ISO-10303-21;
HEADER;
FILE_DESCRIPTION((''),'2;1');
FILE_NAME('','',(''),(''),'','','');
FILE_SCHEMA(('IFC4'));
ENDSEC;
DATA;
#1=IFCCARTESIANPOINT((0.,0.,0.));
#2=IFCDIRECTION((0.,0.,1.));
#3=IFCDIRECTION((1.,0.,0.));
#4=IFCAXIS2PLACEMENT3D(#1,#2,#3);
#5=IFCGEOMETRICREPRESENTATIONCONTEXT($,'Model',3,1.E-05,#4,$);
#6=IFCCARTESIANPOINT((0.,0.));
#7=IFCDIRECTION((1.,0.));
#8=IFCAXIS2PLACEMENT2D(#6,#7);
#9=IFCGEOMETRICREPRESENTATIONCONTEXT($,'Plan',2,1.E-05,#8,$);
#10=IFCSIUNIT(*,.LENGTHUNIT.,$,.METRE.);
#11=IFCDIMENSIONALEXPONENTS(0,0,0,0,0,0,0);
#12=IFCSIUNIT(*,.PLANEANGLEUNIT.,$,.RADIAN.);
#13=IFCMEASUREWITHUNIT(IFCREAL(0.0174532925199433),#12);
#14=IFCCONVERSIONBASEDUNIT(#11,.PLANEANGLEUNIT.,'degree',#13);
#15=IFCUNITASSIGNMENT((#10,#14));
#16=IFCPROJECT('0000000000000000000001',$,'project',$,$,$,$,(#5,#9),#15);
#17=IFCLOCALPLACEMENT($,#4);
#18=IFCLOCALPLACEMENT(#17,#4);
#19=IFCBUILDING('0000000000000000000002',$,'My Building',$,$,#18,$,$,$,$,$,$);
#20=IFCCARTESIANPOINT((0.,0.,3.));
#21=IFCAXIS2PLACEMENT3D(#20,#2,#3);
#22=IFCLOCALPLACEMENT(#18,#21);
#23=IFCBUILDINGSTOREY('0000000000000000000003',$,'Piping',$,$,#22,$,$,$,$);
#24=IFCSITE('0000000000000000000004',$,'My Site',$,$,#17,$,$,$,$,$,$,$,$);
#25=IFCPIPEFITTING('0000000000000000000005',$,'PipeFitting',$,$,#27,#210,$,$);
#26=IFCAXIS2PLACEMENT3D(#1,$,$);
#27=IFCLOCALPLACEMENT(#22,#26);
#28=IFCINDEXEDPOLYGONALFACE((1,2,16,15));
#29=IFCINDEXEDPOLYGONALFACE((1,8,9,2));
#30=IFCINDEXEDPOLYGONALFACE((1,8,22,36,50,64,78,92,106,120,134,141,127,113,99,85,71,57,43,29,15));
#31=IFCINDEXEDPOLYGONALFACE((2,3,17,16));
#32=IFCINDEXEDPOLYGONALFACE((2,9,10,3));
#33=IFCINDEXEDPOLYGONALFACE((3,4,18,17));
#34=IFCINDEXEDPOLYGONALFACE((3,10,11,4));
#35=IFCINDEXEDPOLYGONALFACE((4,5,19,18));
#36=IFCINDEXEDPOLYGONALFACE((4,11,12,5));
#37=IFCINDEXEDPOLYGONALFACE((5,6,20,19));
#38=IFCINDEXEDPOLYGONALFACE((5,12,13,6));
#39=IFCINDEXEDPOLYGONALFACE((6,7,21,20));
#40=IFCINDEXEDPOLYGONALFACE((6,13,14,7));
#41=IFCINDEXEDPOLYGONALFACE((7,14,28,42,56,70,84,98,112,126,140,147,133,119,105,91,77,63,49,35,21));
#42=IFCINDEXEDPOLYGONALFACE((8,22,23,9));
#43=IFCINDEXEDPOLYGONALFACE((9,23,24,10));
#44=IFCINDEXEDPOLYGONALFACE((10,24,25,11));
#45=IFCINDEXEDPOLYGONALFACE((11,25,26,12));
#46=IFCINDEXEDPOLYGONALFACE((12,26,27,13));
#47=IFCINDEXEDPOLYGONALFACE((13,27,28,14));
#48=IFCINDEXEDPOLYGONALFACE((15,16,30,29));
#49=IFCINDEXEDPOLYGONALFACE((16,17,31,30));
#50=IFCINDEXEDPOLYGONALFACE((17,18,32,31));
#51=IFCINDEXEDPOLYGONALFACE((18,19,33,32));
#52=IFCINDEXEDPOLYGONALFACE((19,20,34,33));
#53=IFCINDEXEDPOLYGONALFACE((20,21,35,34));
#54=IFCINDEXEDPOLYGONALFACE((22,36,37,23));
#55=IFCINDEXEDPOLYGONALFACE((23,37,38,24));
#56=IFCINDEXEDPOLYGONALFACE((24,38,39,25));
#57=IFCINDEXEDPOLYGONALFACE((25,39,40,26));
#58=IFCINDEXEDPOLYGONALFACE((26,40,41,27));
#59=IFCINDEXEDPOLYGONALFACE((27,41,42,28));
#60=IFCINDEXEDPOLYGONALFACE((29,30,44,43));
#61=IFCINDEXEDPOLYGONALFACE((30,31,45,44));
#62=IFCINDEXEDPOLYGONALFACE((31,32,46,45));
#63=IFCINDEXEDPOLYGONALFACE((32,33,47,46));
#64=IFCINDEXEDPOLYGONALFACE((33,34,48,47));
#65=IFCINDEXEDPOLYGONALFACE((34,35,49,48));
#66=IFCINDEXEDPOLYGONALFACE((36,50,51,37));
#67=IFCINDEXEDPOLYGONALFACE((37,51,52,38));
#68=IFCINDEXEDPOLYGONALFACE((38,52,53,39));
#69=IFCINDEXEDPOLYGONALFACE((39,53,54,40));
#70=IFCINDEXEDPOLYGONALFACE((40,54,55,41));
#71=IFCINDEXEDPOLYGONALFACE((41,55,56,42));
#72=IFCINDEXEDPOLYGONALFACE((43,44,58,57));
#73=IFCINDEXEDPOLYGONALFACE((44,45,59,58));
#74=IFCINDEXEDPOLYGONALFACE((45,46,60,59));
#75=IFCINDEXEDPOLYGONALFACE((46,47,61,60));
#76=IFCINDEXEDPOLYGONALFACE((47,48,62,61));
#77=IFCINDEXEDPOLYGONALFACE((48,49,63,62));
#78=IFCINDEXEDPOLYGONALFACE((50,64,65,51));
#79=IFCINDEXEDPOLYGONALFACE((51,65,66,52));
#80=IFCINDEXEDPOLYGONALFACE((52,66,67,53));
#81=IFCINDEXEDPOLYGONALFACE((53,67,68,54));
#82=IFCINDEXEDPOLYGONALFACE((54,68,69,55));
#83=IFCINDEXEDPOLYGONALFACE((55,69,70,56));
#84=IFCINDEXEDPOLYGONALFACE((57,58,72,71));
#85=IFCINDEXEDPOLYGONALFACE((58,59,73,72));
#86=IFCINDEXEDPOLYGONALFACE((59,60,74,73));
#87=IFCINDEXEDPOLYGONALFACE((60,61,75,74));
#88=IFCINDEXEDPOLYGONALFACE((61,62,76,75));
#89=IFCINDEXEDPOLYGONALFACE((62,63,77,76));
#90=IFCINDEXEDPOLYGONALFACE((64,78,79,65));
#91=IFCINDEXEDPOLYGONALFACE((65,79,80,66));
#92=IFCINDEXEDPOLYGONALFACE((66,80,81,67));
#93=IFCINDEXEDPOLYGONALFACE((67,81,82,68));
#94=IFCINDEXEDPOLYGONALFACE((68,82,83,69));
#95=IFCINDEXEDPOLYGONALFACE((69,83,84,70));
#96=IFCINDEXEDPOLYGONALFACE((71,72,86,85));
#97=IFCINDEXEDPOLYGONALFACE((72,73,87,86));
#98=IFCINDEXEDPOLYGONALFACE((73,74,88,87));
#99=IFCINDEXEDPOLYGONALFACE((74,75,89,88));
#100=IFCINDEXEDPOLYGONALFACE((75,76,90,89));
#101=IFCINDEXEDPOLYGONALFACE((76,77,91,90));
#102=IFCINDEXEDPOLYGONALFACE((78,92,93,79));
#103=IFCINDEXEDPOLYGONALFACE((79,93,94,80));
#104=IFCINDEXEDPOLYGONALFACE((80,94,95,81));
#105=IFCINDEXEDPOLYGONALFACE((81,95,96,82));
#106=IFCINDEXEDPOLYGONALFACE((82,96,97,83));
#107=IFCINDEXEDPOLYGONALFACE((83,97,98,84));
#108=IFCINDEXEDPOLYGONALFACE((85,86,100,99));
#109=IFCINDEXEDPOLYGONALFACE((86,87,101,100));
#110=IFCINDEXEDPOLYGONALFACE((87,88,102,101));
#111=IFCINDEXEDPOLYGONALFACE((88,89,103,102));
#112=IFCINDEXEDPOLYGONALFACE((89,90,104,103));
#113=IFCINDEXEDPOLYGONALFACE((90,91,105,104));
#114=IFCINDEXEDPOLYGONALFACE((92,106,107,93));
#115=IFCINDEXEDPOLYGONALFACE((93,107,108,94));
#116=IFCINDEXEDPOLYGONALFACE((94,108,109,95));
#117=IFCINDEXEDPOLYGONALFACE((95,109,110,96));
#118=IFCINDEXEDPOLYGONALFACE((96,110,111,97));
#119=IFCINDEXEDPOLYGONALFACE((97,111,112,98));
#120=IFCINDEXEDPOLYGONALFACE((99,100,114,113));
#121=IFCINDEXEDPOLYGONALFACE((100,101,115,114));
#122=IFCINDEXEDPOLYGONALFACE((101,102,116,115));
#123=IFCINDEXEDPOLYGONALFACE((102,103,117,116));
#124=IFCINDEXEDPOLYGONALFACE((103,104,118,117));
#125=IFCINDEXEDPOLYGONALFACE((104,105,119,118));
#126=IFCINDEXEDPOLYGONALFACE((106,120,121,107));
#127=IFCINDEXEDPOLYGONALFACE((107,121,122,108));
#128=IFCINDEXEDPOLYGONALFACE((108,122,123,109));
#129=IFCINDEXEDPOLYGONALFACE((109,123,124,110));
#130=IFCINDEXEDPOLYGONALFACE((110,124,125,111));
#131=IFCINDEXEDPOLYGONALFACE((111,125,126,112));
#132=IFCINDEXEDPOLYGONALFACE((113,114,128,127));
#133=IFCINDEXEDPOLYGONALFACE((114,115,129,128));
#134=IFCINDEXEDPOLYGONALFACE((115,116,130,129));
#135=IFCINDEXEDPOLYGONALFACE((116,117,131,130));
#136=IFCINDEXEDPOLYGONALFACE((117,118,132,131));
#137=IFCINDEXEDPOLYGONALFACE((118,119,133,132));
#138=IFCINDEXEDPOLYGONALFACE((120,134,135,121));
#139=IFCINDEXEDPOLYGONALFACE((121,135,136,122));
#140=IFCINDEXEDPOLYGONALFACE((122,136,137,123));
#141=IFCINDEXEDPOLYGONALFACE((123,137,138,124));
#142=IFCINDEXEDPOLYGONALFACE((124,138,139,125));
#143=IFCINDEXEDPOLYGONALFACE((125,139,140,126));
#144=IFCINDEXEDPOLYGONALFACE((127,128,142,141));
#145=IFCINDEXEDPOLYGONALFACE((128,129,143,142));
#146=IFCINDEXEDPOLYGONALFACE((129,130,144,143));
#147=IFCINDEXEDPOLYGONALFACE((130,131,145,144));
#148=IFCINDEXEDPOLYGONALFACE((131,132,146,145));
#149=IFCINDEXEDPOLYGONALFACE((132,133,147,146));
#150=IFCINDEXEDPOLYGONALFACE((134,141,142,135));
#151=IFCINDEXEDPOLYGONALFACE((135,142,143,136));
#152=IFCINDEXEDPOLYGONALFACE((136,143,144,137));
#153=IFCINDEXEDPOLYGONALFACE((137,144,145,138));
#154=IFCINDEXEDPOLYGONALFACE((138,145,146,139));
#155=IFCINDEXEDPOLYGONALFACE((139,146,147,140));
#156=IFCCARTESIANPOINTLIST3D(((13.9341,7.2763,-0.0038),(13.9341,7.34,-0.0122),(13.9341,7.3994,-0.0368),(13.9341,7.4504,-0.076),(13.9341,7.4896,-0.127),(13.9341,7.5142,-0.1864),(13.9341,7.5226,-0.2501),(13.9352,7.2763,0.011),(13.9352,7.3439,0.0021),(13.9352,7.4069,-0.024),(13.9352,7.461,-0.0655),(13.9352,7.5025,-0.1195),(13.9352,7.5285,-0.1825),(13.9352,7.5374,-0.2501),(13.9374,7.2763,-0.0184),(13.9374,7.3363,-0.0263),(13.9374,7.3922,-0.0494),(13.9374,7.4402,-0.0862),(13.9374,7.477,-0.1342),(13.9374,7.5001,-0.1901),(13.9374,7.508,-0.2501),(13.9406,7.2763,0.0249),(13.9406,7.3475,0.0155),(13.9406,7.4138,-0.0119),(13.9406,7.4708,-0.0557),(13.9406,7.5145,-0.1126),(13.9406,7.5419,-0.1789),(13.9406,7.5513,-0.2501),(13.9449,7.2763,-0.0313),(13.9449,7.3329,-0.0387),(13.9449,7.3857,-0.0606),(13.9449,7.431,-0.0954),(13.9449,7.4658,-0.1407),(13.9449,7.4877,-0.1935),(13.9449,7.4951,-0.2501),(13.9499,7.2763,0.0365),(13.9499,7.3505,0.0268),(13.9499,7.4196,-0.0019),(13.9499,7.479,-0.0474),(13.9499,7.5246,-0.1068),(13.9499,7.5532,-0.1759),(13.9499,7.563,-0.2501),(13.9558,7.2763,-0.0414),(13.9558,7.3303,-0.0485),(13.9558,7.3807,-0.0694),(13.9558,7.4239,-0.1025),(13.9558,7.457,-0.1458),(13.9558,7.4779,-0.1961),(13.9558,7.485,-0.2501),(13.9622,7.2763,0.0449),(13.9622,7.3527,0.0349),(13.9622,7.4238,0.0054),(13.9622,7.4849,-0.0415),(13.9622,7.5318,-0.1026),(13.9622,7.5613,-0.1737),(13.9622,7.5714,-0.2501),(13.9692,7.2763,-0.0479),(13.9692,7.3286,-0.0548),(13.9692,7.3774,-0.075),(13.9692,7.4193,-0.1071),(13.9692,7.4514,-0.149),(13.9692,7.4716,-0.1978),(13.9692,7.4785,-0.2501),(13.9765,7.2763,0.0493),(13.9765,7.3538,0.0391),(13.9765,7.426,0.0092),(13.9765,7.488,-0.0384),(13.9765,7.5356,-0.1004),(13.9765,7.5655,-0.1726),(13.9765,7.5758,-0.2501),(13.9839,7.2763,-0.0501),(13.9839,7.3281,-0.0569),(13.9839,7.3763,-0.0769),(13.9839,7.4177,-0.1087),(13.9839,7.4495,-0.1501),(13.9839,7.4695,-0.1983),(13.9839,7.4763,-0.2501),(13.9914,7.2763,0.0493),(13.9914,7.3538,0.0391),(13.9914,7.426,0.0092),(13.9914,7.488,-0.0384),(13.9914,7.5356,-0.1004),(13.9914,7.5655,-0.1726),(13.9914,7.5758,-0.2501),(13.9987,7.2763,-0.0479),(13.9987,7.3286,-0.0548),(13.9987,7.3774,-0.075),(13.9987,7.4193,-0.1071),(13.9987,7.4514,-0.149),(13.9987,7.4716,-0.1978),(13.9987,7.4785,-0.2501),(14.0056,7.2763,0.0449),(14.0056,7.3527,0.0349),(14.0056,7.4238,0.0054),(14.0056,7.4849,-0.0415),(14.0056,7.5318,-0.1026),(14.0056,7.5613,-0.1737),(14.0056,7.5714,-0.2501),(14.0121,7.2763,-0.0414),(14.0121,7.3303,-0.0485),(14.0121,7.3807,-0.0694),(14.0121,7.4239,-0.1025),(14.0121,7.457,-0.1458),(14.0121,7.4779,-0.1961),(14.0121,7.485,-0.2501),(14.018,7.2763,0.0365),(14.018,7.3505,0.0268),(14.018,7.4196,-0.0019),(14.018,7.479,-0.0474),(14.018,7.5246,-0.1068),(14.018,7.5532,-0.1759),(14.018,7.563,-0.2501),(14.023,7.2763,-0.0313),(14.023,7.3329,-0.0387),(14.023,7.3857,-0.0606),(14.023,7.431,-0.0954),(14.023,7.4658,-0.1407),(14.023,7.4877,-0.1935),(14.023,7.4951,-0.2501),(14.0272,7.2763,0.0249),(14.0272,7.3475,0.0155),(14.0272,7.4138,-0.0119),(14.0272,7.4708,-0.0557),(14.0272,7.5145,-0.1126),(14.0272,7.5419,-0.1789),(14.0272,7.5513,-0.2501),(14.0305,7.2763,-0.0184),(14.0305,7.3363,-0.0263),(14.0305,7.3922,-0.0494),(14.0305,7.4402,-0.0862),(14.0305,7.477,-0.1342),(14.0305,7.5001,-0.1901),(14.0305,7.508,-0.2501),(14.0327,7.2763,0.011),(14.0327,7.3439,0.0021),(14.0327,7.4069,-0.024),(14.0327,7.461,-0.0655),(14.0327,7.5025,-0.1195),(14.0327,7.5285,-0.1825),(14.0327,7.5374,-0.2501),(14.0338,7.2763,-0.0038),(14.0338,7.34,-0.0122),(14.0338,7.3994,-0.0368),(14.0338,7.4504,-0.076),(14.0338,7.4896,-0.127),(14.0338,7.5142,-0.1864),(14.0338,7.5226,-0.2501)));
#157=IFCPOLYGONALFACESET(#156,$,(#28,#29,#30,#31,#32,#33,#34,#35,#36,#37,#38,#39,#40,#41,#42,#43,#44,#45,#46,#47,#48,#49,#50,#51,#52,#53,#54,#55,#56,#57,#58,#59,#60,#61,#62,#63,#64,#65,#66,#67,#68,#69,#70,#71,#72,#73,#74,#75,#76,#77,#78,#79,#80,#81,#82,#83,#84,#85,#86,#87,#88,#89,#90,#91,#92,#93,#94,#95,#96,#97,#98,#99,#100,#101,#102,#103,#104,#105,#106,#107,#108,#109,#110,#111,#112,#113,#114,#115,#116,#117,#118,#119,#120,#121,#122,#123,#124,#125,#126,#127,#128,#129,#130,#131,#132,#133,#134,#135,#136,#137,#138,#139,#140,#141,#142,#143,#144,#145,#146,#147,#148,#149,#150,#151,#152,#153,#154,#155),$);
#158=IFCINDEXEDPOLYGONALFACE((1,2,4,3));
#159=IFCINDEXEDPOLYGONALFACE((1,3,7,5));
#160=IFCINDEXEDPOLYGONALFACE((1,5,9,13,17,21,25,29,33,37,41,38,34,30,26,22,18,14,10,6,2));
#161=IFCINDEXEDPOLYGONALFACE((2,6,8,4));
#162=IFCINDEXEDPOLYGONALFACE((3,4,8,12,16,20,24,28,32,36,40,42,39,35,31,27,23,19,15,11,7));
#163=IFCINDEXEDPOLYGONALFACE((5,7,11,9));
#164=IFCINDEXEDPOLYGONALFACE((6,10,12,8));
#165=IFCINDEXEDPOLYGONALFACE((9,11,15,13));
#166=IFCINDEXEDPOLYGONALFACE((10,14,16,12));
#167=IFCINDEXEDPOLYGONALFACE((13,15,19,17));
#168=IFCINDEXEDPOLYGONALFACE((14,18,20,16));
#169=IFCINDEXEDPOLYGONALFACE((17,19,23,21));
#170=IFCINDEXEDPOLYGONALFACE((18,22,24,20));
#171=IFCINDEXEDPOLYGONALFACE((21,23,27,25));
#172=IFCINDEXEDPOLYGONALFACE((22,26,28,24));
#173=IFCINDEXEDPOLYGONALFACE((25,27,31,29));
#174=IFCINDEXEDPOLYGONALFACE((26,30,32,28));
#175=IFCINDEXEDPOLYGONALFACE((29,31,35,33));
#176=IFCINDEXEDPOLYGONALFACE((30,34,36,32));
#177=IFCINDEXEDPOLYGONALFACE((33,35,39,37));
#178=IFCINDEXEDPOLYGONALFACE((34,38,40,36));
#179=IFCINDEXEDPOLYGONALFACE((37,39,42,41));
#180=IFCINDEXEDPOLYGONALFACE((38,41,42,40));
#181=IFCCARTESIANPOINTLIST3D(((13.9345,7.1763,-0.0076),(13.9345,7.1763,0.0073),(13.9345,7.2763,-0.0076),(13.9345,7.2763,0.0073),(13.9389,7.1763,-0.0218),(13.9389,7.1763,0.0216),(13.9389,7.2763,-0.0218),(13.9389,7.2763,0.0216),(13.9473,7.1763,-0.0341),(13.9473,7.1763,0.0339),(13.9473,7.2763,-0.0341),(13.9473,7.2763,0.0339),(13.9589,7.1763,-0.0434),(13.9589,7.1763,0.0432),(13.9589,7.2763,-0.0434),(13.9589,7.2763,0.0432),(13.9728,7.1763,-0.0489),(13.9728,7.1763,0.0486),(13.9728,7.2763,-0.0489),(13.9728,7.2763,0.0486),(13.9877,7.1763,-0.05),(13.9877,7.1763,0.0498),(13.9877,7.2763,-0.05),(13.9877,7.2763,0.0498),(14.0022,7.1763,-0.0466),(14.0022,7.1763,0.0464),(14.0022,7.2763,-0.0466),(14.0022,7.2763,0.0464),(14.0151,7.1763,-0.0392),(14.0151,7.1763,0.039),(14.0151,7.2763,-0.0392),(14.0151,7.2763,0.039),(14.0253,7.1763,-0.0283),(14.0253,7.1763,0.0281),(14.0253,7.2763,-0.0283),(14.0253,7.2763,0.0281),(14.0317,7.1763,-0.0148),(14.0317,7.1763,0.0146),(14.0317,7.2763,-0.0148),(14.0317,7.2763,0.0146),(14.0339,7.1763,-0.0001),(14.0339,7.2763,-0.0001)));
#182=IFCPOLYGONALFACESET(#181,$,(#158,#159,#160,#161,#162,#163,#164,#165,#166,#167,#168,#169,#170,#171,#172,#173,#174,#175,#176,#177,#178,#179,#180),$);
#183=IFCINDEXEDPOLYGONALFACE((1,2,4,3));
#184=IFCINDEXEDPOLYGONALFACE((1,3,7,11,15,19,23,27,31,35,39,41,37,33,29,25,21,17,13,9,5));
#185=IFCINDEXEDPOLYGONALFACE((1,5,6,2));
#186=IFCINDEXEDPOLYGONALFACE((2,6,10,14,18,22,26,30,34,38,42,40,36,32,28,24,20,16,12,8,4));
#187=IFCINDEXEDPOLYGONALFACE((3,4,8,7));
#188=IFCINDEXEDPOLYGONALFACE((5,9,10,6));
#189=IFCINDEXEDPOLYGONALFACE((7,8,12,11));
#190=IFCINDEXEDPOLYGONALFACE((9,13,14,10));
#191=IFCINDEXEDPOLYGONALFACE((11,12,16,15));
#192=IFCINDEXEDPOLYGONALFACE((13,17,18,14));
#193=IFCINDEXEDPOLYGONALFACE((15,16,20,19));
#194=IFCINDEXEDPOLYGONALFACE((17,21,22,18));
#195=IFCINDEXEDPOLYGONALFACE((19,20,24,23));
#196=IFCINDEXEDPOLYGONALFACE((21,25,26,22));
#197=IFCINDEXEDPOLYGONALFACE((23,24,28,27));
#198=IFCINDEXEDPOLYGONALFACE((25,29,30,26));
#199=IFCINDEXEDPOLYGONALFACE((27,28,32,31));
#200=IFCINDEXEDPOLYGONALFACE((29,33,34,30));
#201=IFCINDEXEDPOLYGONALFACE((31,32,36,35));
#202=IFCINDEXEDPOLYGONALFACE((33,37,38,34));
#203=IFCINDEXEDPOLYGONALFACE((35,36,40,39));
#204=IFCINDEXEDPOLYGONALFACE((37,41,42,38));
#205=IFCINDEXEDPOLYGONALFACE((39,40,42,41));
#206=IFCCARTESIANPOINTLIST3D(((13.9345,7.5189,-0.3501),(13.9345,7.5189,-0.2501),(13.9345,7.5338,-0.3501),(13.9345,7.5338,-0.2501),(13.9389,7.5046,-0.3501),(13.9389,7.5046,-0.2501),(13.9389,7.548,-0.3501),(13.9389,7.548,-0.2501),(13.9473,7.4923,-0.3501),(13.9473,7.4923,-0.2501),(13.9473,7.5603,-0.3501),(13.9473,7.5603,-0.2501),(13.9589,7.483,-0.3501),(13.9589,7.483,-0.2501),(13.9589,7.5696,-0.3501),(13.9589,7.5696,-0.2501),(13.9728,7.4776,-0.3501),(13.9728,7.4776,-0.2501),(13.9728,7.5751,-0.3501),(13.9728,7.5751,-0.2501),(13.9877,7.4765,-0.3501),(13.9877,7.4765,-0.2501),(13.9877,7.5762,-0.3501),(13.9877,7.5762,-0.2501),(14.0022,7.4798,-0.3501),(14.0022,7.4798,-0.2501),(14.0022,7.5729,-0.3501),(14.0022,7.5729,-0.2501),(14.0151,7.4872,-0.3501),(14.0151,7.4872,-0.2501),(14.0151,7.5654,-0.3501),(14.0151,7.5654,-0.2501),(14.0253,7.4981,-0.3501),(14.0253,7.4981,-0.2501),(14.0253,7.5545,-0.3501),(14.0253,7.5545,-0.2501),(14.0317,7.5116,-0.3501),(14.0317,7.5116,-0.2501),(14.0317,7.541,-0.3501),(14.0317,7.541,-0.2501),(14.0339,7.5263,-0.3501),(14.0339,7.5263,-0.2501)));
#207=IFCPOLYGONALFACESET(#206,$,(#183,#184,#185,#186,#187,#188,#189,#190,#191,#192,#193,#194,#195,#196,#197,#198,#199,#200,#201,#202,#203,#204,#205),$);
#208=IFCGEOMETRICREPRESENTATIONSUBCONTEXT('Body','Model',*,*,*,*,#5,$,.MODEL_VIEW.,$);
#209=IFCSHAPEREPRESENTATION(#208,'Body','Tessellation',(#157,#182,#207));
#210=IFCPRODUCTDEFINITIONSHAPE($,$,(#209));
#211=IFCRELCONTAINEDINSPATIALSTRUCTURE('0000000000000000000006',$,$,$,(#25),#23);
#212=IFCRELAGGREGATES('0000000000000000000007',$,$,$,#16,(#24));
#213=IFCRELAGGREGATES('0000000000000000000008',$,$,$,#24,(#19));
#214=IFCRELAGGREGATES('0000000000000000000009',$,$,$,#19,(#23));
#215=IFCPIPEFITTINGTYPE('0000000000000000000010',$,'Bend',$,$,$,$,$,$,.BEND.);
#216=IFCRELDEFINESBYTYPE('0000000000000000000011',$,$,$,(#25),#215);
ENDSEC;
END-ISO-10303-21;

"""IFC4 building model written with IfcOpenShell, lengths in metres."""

from ifc_helpers import new_model, entity, si_unit, converted_unit, frame, origin_with_axes, origin_2d_with_axis, place, context, subcontext, project, spatial, circle, extrude, source, transform, mapped, type_object, type_shapes, element, save


model = new_model("IFC4")

# Units and contexts
model_context = context("Model", 3, precision=1e-05, world=origin_with_axes())
plan_context = context("Plan", 2, precision=1e-05, world=origin_2d_with_axis())
body_context = subcontext(model_context, "Body", "Model", "MODEL_VIEW")
ifc_project = project(units=[si_unit("LENGTHUNIT", "METRE"), converted_unit("PLANEANGLEUNIT", "degree", entity("IfcReal", 0.0174532925199433), si_unit("PLANEANGLEUNIT", "RADIAN"), dimensions=[0, 0, 0, 0, 0, 0, 0])], contexts=[model_context, plan_context])

# Site, building, storey
site_placement = place(None, origin_with_axes())
site = spatial("IfcSite", under=ifc_project, at=site_placement, Name="My Site")
building_placement = place(site_placement, origin_with_axes())
building = spatial("IfcBuilding", under=site, at=building_placement, Name="My Building")
storey_placement = place(building_placement, frame((0.0, 0.0, 3.0), z_axis=(0.0, 0.0, 1.0), x_axis=(1.0, 0.0, 0.0)))
storey = spatial("IfcBuildingStorey", under=building, at=storey_placement, Name="Piping")

# Pipe fitting
pipe_fitting_type = type_object("IfcPipeFittingType", Name="Bend", PredefinedType="BEND")
shared_shape = source(origin_with_axes(), body_context, "Body", "SolidModel", [
    entity("IfcSweptDiskSolid", entity("IfcIndexedPolyCurve", entity("IfcCartesianPointList3D", [[0.0, 0.0, -0.1], [0.0, -0.0732, -0.2768], [0.0, -0.25, -0.35]]), [entity("IfcArcIndex", [1, 2, 3])]), 0.05),
    extrude(circle(Radius=0.05), origin_with_axes(), (0.0, 0.0, -1.0), 0.1),
    extrude(circle(Radius=0.05), frame((0.0, -0.25, -0.35), z_axis=(0.0, -1.0, 0.0), x_axis=(1.0, 0.0, 0.0)), (0.0, 0.0, 1.0), 0.1),
])
type_shapes(pipe_fitting_type, [shared_shape])
for number, where, z_axis, x_axis, name in (
    (1, (13.9839, 7.1763, -0.0001), (0.0, -1.0, 0.0), (1.0, 0.0, 0.0), "PipeFitting"),
):
    element("IfcPipeFitting", number, at=place(storey_placement, frame(where, z_axis=z_axis, x_axis=x_axis)), inside=storey, type_object=pipe_fitting_type, Name=name, context=body_context, shape_type="MappedRepresentation", body=[
        mapped(shared_shape, transform((0.0, 0.0, 0.0), x_axis=(1.0, 0.0, 0.0), y_axis=(0.0, 1.0, 0.0), z_axis=(0.0, 0.0, 1.0), scale=1.0)),
    ])

save(model, "model.ifc")
